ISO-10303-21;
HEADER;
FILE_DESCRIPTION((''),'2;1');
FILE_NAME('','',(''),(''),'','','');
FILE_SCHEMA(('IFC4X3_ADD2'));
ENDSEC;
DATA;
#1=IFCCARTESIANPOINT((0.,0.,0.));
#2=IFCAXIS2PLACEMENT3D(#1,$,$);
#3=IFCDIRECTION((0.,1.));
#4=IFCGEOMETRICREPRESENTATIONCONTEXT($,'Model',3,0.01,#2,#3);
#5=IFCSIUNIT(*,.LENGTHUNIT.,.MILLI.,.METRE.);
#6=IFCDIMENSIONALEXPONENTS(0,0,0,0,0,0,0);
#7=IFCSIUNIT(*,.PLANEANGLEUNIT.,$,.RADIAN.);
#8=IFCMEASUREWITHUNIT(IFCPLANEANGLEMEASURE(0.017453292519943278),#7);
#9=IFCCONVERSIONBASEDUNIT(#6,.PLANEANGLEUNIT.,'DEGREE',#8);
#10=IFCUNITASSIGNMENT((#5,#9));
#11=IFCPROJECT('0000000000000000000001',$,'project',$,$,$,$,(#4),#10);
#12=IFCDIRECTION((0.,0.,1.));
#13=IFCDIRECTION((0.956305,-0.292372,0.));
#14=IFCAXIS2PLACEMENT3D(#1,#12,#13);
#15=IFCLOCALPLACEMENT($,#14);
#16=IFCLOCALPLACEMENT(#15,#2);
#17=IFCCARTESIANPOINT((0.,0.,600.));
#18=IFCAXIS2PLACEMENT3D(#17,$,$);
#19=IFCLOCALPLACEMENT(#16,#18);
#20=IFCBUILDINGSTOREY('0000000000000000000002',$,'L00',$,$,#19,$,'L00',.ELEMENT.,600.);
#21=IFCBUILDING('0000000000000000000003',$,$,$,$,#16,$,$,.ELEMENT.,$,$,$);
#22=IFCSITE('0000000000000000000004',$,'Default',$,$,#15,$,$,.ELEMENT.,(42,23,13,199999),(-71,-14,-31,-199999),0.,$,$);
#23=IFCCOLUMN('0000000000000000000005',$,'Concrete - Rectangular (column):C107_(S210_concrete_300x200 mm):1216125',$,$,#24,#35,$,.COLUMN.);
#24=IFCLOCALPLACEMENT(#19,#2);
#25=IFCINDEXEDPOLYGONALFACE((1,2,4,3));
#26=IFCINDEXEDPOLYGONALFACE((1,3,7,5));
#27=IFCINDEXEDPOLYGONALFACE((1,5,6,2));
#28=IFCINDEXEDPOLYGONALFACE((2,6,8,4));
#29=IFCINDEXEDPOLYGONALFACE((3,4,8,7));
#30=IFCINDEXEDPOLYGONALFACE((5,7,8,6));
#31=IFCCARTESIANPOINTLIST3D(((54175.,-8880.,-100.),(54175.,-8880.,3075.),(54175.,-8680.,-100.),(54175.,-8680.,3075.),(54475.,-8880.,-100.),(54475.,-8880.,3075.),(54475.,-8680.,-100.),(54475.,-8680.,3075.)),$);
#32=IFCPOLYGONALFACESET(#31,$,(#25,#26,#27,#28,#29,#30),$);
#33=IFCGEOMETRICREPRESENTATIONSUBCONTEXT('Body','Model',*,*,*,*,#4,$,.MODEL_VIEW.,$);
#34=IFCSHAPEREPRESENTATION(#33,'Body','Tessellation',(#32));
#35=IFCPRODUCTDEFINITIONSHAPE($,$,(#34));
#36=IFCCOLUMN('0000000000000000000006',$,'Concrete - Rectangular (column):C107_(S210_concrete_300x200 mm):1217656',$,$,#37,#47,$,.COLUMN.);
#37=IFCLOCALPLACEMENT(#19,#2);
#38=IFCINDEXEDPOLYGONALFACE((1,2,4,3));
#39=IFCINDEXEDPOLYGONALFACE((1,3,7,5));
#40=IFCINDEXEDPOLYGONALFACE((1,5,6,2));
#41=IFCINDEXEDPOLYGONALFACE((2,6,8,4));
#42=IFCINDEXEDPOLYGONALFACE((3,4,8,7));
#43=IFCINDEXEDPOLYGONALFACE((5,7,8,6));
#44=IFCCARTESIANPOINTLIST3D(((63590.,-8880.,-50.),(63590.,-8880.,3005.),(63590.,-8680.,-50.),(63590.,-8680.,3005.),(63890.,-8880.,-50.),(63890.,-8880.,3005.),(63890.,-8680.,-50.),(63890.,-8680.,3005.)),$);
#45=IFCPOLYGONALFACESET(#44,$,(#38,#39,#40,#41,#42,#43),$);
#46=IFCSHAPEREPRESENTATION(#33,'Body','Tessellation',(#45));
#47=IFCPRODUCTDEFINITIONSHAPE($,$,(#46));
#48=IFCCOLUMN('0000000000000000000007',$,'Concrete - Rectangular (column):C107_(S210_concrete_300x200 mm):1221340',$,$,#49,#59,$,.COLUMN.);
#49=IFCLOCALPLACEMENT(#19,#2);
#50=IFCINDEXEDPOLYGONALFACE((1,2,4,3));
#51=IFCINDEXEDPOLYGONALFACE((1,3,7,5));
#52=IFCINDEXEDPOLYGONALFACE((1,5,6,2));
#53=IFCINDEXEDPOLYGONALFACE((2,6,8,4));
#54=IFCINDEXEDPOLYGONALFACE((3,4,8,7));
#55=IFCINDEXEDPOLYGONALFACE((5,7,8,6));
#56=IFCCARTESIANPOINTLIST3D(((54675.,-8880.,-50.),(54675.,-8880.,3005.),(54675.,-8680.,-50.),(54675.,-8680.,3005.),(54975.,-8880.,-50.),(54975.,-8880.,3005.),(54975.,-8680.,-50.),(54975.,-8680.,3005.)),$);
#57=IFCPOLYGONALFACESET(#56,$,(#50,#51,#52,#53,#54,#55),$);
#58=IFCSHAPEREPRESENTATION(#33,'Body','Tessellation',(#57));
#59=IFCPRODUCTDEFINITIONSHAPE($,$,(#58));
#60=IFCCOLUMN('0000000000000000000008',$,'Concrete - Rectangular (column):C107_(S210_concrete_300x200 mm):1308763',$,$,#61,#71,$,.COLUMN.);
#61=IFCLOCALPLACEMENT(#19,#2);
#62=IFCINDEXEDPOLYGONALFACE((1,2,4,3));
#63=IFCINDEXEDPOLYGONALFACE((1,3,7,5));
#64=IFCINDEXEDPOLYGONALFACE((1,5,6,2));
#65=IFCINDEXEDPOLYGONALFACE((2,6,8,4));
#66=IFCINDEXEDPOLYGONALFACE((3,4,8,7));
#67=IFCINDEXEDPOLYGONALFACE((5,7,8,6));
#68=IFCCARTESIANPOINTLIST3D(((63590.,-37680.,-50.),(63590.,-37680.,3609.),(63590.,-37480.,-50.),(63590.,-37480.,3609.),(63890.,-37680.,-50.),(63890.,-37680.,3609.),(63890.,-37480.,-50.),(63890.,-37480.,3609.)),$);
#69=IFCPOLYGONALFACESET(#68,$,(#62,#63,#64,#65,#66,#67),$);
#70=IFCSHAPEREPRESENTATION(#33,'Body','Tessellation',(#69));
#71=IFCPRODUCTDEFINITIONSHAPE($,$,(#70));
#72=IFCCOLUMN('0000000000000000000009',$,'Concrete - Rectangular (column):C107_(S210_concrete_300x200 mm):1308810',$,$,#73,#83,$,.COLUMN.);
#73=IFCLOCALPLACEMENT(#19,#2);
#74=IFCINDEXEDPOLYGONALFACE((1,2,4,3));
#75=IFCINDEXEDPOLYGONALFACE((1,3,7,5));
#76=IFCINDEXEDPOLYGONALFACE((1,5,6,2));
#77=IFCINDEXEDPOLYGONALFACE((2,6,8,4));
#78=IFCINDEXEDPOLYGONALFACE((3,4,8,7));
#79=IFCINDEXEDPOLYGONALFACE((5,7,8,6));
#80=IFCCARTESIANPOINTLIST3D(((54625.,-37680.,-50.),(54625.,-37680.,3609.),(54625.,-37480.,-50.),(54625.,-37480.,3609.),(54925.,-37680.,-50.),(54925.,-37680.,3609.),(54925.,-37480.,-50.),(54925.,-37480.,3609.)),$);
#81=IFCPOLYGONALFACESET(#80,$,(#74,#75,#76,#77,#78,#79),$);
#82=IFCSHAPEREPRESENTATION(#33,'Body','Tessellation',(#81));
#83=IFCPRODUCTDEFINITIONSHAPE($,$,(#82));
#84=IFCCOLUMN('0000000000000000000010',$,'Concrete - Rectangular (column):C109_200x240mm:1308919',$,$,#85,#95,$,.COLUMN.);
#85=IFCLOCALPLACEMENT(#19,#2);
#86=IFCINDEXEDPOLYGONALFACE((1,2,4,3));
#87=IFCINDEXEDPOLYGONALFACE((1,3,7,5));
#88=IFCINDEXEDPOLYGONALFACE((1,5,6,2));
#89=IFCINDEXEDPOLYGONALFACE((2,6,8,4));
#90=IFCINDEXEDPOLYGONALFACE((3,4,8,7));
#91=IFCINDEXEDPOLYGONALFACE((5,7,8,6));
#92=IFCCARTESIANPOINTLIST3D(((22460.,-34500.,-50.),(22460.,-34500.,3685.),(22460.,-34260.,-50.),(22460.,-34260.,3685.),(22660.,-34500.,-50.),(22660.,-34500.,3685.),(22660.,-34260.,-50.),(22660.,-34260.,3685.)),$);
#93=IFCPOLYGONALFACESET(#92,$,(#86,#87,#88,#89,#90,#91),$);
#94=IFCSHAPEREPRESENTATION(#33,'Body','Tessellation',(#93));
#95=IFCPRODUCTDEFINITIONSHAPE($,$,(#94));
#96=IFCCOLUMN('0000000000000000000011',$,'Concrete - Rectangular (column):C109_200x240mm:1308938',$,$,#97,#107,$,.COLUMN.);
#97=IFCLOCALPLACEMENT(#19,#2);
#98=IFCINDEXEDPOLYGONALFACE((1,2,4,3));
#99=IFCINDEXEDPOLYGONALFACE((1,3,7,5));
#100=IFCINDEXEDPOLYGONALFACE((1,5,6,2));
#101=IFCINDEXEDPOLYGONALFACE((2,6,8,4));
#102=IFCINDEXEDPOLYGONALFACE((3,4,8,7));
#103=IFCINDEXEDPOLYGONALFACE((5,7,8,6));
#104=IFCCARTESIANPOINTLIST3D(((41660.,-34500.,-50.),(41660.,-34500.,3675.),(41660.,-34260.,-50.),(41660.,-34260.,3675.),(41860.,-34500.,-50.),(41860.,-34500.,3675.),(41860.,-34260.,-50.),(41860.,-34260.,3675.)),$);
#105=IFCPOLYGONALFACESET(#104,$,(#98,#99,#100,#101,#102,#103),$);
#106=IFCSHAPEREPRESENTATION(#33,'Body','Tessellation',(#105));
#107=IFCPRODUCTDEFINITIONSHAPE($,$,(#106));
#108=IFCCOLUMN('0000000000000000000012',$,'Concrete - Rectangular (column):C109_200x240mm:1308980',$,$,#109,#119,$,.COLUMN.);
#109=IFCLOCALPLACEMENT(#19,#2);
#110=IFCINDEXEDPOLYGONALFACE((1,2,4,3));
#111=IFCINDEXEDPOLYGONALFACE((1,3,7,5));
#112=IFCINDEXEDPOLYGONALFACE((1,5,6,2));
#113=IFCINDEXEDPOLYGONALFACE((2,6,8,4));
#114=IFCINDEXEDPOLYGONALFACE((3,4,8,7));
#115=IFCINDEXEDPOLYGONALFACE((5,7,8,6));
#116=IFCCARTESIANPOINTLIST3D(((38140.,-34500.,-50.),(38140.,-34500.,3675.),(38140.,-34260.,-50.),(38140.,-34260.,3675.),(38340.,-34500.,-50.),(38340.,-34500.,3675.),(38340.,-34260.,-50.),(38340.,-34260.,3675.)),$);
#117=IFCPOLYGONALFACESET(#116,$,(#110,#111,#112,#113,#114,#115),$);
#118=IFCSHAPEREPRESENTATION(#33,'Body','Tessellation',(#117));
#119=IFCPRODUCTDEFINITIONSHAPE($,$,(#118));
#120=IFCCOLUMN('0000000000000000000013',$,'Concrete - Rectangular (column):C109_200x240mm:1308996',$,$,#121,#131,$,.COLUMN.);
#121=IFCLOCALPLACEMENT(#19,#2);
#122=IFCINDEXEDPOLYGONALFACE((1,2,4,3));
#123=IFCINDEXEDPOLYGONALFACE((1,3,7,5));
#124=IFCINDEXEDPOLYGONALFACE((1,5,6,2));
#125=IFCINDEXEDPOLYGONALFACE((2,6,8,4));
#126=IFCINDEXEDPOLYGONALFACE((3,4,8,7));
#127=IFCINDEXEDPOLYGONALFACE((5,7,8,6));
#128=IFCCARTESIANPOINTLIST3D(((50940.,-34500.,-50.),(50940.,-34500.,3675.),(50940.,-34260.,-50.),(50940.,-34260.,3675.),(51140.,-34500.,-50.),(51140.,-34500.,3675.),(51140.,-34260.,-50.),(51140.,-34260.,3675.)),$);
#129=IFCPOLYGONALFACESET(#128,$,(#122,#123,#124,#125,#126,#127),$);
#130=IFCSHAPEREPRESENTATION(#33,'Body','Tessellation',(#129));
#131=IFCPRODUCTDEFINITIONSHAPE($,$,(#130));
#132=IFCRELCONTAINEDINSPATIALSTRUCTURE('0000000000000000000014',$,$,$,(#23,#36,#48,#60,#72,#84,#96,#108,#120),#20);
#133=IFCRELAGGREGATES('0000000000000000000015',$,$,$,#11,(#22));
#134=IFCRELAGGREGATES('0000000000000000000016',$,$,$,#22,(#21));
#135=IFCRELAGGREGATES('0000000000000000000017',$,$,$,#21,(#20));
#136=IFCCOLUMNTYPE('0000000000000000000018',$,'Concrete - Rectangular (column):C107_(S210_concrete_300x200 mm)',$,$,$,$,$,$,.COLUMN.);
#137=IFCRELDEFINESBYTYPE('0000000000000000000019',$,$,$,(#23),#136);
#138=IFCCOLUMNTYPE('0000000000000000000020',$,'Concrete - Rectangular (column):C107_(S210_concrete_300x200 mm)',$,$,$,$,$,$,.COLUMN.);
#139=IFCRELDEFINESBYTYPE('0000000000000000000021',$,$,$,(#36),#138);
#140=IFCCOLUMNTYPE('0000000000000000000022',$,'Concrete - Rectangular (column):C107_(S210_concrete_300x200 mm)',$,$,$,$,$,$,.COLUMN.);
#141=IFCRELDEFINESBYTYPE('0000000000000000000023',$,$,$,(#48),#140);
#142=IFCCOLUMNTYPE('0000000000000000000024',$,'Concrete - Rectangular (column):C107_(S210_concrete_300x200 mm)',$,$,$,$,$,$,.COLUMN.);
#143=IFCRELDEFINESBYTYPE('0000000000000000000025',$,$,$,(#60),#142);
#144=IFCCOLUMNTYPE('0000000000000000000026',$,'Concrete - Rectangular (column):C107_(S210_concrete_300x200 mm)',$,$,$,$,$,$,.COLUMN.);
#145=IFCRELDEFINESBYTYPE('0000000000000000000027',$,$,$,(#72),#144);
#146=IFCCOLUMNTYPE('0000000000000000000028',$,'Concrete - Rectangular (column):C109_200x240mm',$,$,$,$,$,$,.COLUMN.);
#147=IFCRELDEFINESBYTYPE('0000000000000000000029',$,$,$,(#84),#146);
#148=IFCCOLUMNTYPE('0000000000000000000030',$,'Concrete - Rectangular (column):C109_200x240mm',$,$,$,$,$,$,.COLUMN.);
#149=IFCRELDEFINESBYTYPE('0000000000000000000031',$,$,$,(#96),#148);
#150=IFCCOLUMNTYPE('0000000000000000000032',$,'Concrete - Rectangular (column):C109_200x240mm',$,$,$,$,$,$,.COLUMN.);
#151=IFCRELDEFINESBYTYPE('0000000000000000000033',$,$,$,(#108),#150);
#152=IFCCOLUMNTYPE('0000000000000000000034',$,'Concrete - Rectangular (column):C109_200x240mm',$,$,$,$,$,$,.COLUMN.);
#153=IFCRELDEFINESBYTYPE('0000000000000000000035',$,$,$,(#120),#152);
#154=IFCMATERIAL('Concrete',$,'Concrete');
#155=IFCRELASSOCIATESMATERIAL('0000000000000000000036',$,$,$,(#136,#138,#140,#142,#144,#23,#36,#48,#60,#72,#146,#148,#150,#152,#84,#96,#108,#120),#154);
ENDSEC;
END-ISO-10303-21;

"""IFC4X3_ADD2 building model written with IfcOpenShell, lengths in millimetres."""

from ifc_helpers import new_model, entity, si_unit, converted_unit, direction, frame, frame_2d, origin, origin_2d_with_axis, place, context, subcontext, project, spatial, rectangle, extrude, source, transform, mapped, material, material_profile, profile_set, profile_usage, type_object, type_shapes, element, save


model = new_model("IFC4X3_ADD2")

# Units and contexts
model_context = context("Model", 3, precision=0.01, world=origin(), true_north=direction((0.0, 1.0)))
body_context = subcontext(model_context, "Body", "Model", "MODEL_VIEW")
ifc_project = project(units=[si_unit("LENGTHUNIT", "METRE", prefix="MILLI"), converted_unit("PLANEANGLEUNIT", "DEGREE", entity("IfcPlaneAngleMeasure", 0.017453292519943278), si_unit("PLANEANGLEUNIT", "RADIAN"), dimensions=[0, 0, 0, 0, 0, 0, 0])], contexts=[model_context])

# Site, building, storey
site_placement = place(None, frame((0.0, 0.0, 0.0), z_axis=(0.0, 0.0, 1.0), x_axis=(0.956305, -0.292372, 0.0)))
site = spatial("IfcSite", under=ifc_project, at=site_placement, Name="Default", CompositionType="ELEMENT", RefLatitude=(42, 23, 13, 199999), RefLongitude=(-71, -14, -31, -199999), RefElevation=0.0)
building_placement = place(site_placement, origin())
building = spatial("IfcBuilding", under=site, at=building_placement, CompositionType="ELEMENT")
storey_placement = place(building_placement, frame((0.0, 0.0, 600.0)))
storey = spatial("IfcBuildingStorey", under=building, at=storey_placement, Name="L00", LongName="L00", CompositionType="ELEMENT", Elevation=600.0)

# Columns
ifc_material = material(Name="Concrete", Category="Concrete")
ifc_material_profile_1 = material_profile(ifc_material, rectangle(XDim=300.0, YDim=200.0, at=frame_2d((0.0, 0.0), x_axis=(1.0, 0.0))), Name="C107_(S210_concrete_300x200 mm)")
ifc_profile_set_1 = profile_set([ifc_material_profile_1], Name="C107_(S210_concrete_300x200 mm)")
ifc_profile_usage_1 = profile_usage(ifc_profile_set_1)
column_type_1 = type_object("IfcColumnType", Name="Concrete - Rectangular (column):C107_(S210_concrete_300x200 mm)", PredefinedType="COLUMN", material=ifc_profile_set_1)
shared_shape_1 = source(origin(), body_context, "Body", "SweptSolid", [
    extrude(rectangle(XDim=200.0, YDim=300.0, at=frame_2d((0.0, 0.0), x_axis=(1.0, 0.0))), frame((54325.0, -8780.0, 500.0), z_axis=(0.0, 0.0, 1.0), x_axis=(0.0, 1.0, 0.0)), (0.0, 0.0, 1.0), 3175.0),
])
type_shapes(column_type_1, [shared_shape_1])
column_1_placement = place(storey_placement, frame((0.0, 0.0, -600.0)))
element("IfcColumn", 1, at=column_1_placement, inside=storey, type_object=column_type_1, material=ifc_profile_usage_1, Name="Concrete - Rectangular (column):C107_(S210_concrete_300x200 mm):1216125", PredefinedType="COLUMN", context=body_context, shape_type="MappedRepresentation", body=[
    mapped(shared_shape_1, transform((0.0, 0.0, 0.0), scale=1.0)),
])
column_type_2 = type_object("IfcColumnType", Name="Concrete - Rectangular (column):C107_(S210_concrete_300x200 mm)", PredefinedType="COLUMN", material=ifc_profile_set_1)
shared_shape_2 = source(origin(), body_context, "Body", "SweptSolid", [
    extrude(rectangle(XDim=200.0, YDim=300.0, at=frame_2d((0.0, 0.0), x_axis=(1.0, 0.0))), frame((63740.0, -8780.0, 550.0), z_axis=(0.0, 0.0, 1.0), x_axis=(0.0, 1.0, 0.0)), (0.0, 0.0, 1.0), 3055.0),
])
type_shapes(column_type_2, [shared_shape_2])
column_2_placement = place(storey_placement, frame((0.0, 0.0, -600.0)))
element("IfcColumn", 2, at=column_2_placement, inside=storey, type_object=column_type_2, material=ifc_profile_usage_1, Name="Concrete - Rectangular (column):C107_(S210_concrete_300x200 mm):1217656", PredefinedType="COLUMN", context=body_context, shape_type="MappedRepresentation", body=[
    mapped(shared_shape_2, transform((0.0, 0.0, 0.0), scale=1.0)),
])
column_type_3 = type_object("IfcColumnType", Name="Concrete - Rectangular (column):C107_(S210_concrete_300x200 mm)", PredefinedType="COLUMN", material=ifc_profile_set_1)
shared_shape_3 = source(origin(), body_context, "Body", "SweptSolid", [
    extrude(rectangle(XDim=200.0, YDim=300.0, at=frame_2d((0.0, 0.0), x_axis=(1.0, 0.0))), frame((54825.0, -8780.0, 550.0), z_axis=(0.0, 0.0, 1.0), x_axis=(0.0, 1.0, 0.0)), (0.0, 0.0, 1.0), 3055.0),
])
type_shapes(column_type_3, [shared_shape_3])
column_3_placement = place(storey_placement, frame((0.0, 0.0, -600.0)))
element("IfcColumn", 3, at=column_3_placement, inside=storey, type_object=column_type_3, material=ifc_profile_usage_1, Name="Concrete - Rectangular (column):C107_(S210_concrete_300x200 mm):1221340", PredefinedType="COLUMN", context=body_context, shape_type="MappedRepresentation", body=[
    mapped(shared_shape_3, transform((0.0, 0.0, 0.0), scale=1.0)),
])
column_type_4 = type_object("IfcColumnType", Name="Concrete - Rectangular (column):C107_(S210_concrete_300x200 mm)", PredefinedType="COLUMN", material=ifc_profile_set_1)
shared_shape_4 = source(origin(), body_context, "Body", "SweptSolid", [
    extrude(rectangle(XDim=300.0, YDim=200.0, at=origin_2d_with_axis()), frame((63740.0, -37580.0, 550.0), z_axis=(0.0, 0.0, 1.0), x_axis=(-1.0, 0.0, 0.0)), (0.0, 0.0, 1.0), 3659.0),
])
type_shapes(column_type_4, [shared_shape_4])
column_4_placement = place(storey_placement, frame((0.0, 0.0, -600.0)))
element("IfcColumn", 4, at=column_4_placement, inside=storey, type_object=column_type_4, material=ifc_profile_usage_1, Name="Concrete - Rectangular (column):C107_(S210_concrete_300x200 mm):1308763", PredefinedType="COLUMN", context=body_context, shape_type="MappedRepresentation", body=[
    mapped(shared_shape_4, transform((0.0, 0.0, 0.0), scale=1.0)),
])
column_type_5 = type_object("IfcColumnType", Name="Concrete - Rectangular (column):C107_(S210_concrete_300x200 mm)", PredefinedType="COLUMN", material=ifc_profile_set_1)
shared_shape_5 = source(origin(), body_context, "Body", "SweptSolid", [
    extrude(rectangle(XDim=300.0, YDim=200.0, at=origin_2d_with_axis()), frame((54775.0, -37580.0, 550.0), z_axis=(0.0, 0.0, 1.0), x_axis=(-1.0, 0.0, 0.0)), (0.0, 0.0, 1.0), 3659.0),
])
type_shapes(column_type_5, [shared_shape_5])
column_5_placement = place(storey_placement, frame((0.0, 0.0, -600.0)))
element("IfcColumn", 5, at=column_5_placement, inside=storey, type_object=column_type_5, material=ifc_profile_usage_1, Name="Concrete - Rectangular (column):C107_(S210_concrete_300x200 mm):1308810", PredefinedType="COLUMN", context=body_context, shape_type="MappedRepresentation", body=[
    mapped(shared_shape_5, transform((0.0, 0.0, 0.0), scale=1.0)),
])
ifc_material_profile_2 = material_profile(ifc_material, rectangle(XDim=200.0, YDim=240.0, at=frame_2d((0.0, 0.0), x_axis=(1.0, 0.0))), Name="C109_200x240mm")
ifc_profile_set_2 = profile_set([ifc_material_profile_2], Name="C109_200x240mm")
ifc_profile_usage_2 = profile_usage(ifc_profile_set_2)
column_type_6 = type_object("IfcColumnType", Name="Concrete - Rectangular (column):C109_200x240mm", PredefinedType="COLUMN", material=ifc_profile_set_2)
shared_shape_6 = source(origin(), body_context, "Body", "SweptSolid", [
    extrude(rectangle(XDim=200.0, YDim=240.0, at=frame_2d((0.0, 0.0), x_axis=(1.0, 0.0))), frame((22560.0, -34380.0, 550.0), z_axis=(0.0, 0.0, 1.0), x_axis=(-1.0, 0.0, 0.0)), (0.0, 0.0, 1.0), 3735.0),
])
type_shapes(column_type_6, [shared_shape_6])
column_6_placement = place(storey_placement, frame((0.0, 0.0, -600.0)))
element("IfcColumn", 6, at=column_6_placement, inside=storey, type_object=column_type_6, material=ifc_profile_usage_2, Name="Concrete - Rectangular (column):C109_200x240mm:1308919", PredefinedType="COLUMN", context=body_context, shape_type="MappedRepresentation", body=[
    mapped(shared_shape_6, transform((0.0, 0.0, 0.0), scale=1.0)),
])
column_type_7 = type_object("IfcColumnType", Name="Concrete - Rectangular (column):C109_200x240mm", PredefinedType="COLUMN", material=ifc_profile_set_2)
shared_shape_7 = source(origin(), body_context, "Body", "SweptSolid", [
    extrude(rectangle(XDim=200.0, YDim=240.0, at=frame_2d((0.0, 0.0), x_axis=(1.0, 0.0))), frame((41760.0, -34380.0, 550.0), z_axis=(0.0, 0.0, 1.0), x_axis=(-1.0, 0.0, 0.0)), (0.0, 0.0, 1.0), 3725.0),
])
type_shapes(column_type_7, [shared_shape_7])
column_7_placement = place(storey_placement, frame((0.0, 0.0, -600.0)))
element("IfcColumn", 7, at=column_7_placement, inside=storey, type_object=column_type_7, material=ifc_profile_usage_2, Name="Concrete - Rectangular (column):C109_200x240mm:1308938", PredefinedType="COLUMN", context=body_context, shape_type="MappedRepresentation", body=[
    mapped(shared_shape_7, transform((0.0, 0.0, 0.0), scale=1.0)),
])
column_type_8 = type_object("IfcColumnType", Name="Concrete - Rectangular (column):C109_200x240mm", PredefinedType="COLUMN", material=ifc_profile_set_2)
shared_shape_8 = source(origin(), body_context, "Body", "SweptSolid", [
    extrude(rectangle(XDim=200.0, YDim=240.0, at=frame_2d((0.0, 0.0), x_axis=(1.0, 0.0))), frame((38240.0, -34380.0, 550.0), z_axis=(0.0, 0.0, 1.0), x_axis=(-1.0, 0.0, 0.0)), (0.0, 0.0, 1.0), 3725.0),
])
type_shapes(column_type_8, [shared_shape_8])
column_8_placement = place(storey_placement, frame((0.0, 0.0, -600.0)))
element("IfcColumn", 8, at=column_8_placement, inside=storey, type_object=column_type_8, material=ifc_profile_usage_2, Name="Concrete - Rectangular (column):C109_200x240mm:1308980", PredefinedType="COLUMN", context=body_context, shape_type="MappedRepresentation", body=[
    mapped(shared_shape_8, transform((0.0, 0.0, 0.0), scale=1.0)),
])
column_type_9 = type_object("IfcColumnType", Name="Concrete - Rectangular (column):C109_200x240mm", PredefinedType="COLUMN", material=ifc_profile_set_2)
shared_shape_9 = source(origin(), body_context, "Body", "SweptSolid", [
    extrude(rectangle(XDim=200.0, YDim=240.0, at=frame_2d((0.0, 0.0), x_axis=(1.0, 0.0))), frame((51040.0, -34380.0, 550.0), z_axis=(0.0, 0.0, 1.0), x_axis=(-1.0, 0.0, 0.0)), (0.0, 0.0, 1.0), 3725.0),
])
type_shapes(column_type_9, [shared_shape_9])
column_9_placement = place(storey_placement, frame((0.0, 0.0, -600.0)))
element("IfcColumn", 9, at=column_9_placement, inside=storey, type_object=column_type_9, material=ifc_profile_usage_2, Name="Concrete - Rectangular (column):C109_200x240mm:1308996", PredefinedType="COLUMN", context=body_context, shape_type="MappedRepresentation", body=[
    mapped(shared_shape_9, transform((0.0, 0.0, 0.0), scale=1.0)),
])

save(model, "model.ifc")
